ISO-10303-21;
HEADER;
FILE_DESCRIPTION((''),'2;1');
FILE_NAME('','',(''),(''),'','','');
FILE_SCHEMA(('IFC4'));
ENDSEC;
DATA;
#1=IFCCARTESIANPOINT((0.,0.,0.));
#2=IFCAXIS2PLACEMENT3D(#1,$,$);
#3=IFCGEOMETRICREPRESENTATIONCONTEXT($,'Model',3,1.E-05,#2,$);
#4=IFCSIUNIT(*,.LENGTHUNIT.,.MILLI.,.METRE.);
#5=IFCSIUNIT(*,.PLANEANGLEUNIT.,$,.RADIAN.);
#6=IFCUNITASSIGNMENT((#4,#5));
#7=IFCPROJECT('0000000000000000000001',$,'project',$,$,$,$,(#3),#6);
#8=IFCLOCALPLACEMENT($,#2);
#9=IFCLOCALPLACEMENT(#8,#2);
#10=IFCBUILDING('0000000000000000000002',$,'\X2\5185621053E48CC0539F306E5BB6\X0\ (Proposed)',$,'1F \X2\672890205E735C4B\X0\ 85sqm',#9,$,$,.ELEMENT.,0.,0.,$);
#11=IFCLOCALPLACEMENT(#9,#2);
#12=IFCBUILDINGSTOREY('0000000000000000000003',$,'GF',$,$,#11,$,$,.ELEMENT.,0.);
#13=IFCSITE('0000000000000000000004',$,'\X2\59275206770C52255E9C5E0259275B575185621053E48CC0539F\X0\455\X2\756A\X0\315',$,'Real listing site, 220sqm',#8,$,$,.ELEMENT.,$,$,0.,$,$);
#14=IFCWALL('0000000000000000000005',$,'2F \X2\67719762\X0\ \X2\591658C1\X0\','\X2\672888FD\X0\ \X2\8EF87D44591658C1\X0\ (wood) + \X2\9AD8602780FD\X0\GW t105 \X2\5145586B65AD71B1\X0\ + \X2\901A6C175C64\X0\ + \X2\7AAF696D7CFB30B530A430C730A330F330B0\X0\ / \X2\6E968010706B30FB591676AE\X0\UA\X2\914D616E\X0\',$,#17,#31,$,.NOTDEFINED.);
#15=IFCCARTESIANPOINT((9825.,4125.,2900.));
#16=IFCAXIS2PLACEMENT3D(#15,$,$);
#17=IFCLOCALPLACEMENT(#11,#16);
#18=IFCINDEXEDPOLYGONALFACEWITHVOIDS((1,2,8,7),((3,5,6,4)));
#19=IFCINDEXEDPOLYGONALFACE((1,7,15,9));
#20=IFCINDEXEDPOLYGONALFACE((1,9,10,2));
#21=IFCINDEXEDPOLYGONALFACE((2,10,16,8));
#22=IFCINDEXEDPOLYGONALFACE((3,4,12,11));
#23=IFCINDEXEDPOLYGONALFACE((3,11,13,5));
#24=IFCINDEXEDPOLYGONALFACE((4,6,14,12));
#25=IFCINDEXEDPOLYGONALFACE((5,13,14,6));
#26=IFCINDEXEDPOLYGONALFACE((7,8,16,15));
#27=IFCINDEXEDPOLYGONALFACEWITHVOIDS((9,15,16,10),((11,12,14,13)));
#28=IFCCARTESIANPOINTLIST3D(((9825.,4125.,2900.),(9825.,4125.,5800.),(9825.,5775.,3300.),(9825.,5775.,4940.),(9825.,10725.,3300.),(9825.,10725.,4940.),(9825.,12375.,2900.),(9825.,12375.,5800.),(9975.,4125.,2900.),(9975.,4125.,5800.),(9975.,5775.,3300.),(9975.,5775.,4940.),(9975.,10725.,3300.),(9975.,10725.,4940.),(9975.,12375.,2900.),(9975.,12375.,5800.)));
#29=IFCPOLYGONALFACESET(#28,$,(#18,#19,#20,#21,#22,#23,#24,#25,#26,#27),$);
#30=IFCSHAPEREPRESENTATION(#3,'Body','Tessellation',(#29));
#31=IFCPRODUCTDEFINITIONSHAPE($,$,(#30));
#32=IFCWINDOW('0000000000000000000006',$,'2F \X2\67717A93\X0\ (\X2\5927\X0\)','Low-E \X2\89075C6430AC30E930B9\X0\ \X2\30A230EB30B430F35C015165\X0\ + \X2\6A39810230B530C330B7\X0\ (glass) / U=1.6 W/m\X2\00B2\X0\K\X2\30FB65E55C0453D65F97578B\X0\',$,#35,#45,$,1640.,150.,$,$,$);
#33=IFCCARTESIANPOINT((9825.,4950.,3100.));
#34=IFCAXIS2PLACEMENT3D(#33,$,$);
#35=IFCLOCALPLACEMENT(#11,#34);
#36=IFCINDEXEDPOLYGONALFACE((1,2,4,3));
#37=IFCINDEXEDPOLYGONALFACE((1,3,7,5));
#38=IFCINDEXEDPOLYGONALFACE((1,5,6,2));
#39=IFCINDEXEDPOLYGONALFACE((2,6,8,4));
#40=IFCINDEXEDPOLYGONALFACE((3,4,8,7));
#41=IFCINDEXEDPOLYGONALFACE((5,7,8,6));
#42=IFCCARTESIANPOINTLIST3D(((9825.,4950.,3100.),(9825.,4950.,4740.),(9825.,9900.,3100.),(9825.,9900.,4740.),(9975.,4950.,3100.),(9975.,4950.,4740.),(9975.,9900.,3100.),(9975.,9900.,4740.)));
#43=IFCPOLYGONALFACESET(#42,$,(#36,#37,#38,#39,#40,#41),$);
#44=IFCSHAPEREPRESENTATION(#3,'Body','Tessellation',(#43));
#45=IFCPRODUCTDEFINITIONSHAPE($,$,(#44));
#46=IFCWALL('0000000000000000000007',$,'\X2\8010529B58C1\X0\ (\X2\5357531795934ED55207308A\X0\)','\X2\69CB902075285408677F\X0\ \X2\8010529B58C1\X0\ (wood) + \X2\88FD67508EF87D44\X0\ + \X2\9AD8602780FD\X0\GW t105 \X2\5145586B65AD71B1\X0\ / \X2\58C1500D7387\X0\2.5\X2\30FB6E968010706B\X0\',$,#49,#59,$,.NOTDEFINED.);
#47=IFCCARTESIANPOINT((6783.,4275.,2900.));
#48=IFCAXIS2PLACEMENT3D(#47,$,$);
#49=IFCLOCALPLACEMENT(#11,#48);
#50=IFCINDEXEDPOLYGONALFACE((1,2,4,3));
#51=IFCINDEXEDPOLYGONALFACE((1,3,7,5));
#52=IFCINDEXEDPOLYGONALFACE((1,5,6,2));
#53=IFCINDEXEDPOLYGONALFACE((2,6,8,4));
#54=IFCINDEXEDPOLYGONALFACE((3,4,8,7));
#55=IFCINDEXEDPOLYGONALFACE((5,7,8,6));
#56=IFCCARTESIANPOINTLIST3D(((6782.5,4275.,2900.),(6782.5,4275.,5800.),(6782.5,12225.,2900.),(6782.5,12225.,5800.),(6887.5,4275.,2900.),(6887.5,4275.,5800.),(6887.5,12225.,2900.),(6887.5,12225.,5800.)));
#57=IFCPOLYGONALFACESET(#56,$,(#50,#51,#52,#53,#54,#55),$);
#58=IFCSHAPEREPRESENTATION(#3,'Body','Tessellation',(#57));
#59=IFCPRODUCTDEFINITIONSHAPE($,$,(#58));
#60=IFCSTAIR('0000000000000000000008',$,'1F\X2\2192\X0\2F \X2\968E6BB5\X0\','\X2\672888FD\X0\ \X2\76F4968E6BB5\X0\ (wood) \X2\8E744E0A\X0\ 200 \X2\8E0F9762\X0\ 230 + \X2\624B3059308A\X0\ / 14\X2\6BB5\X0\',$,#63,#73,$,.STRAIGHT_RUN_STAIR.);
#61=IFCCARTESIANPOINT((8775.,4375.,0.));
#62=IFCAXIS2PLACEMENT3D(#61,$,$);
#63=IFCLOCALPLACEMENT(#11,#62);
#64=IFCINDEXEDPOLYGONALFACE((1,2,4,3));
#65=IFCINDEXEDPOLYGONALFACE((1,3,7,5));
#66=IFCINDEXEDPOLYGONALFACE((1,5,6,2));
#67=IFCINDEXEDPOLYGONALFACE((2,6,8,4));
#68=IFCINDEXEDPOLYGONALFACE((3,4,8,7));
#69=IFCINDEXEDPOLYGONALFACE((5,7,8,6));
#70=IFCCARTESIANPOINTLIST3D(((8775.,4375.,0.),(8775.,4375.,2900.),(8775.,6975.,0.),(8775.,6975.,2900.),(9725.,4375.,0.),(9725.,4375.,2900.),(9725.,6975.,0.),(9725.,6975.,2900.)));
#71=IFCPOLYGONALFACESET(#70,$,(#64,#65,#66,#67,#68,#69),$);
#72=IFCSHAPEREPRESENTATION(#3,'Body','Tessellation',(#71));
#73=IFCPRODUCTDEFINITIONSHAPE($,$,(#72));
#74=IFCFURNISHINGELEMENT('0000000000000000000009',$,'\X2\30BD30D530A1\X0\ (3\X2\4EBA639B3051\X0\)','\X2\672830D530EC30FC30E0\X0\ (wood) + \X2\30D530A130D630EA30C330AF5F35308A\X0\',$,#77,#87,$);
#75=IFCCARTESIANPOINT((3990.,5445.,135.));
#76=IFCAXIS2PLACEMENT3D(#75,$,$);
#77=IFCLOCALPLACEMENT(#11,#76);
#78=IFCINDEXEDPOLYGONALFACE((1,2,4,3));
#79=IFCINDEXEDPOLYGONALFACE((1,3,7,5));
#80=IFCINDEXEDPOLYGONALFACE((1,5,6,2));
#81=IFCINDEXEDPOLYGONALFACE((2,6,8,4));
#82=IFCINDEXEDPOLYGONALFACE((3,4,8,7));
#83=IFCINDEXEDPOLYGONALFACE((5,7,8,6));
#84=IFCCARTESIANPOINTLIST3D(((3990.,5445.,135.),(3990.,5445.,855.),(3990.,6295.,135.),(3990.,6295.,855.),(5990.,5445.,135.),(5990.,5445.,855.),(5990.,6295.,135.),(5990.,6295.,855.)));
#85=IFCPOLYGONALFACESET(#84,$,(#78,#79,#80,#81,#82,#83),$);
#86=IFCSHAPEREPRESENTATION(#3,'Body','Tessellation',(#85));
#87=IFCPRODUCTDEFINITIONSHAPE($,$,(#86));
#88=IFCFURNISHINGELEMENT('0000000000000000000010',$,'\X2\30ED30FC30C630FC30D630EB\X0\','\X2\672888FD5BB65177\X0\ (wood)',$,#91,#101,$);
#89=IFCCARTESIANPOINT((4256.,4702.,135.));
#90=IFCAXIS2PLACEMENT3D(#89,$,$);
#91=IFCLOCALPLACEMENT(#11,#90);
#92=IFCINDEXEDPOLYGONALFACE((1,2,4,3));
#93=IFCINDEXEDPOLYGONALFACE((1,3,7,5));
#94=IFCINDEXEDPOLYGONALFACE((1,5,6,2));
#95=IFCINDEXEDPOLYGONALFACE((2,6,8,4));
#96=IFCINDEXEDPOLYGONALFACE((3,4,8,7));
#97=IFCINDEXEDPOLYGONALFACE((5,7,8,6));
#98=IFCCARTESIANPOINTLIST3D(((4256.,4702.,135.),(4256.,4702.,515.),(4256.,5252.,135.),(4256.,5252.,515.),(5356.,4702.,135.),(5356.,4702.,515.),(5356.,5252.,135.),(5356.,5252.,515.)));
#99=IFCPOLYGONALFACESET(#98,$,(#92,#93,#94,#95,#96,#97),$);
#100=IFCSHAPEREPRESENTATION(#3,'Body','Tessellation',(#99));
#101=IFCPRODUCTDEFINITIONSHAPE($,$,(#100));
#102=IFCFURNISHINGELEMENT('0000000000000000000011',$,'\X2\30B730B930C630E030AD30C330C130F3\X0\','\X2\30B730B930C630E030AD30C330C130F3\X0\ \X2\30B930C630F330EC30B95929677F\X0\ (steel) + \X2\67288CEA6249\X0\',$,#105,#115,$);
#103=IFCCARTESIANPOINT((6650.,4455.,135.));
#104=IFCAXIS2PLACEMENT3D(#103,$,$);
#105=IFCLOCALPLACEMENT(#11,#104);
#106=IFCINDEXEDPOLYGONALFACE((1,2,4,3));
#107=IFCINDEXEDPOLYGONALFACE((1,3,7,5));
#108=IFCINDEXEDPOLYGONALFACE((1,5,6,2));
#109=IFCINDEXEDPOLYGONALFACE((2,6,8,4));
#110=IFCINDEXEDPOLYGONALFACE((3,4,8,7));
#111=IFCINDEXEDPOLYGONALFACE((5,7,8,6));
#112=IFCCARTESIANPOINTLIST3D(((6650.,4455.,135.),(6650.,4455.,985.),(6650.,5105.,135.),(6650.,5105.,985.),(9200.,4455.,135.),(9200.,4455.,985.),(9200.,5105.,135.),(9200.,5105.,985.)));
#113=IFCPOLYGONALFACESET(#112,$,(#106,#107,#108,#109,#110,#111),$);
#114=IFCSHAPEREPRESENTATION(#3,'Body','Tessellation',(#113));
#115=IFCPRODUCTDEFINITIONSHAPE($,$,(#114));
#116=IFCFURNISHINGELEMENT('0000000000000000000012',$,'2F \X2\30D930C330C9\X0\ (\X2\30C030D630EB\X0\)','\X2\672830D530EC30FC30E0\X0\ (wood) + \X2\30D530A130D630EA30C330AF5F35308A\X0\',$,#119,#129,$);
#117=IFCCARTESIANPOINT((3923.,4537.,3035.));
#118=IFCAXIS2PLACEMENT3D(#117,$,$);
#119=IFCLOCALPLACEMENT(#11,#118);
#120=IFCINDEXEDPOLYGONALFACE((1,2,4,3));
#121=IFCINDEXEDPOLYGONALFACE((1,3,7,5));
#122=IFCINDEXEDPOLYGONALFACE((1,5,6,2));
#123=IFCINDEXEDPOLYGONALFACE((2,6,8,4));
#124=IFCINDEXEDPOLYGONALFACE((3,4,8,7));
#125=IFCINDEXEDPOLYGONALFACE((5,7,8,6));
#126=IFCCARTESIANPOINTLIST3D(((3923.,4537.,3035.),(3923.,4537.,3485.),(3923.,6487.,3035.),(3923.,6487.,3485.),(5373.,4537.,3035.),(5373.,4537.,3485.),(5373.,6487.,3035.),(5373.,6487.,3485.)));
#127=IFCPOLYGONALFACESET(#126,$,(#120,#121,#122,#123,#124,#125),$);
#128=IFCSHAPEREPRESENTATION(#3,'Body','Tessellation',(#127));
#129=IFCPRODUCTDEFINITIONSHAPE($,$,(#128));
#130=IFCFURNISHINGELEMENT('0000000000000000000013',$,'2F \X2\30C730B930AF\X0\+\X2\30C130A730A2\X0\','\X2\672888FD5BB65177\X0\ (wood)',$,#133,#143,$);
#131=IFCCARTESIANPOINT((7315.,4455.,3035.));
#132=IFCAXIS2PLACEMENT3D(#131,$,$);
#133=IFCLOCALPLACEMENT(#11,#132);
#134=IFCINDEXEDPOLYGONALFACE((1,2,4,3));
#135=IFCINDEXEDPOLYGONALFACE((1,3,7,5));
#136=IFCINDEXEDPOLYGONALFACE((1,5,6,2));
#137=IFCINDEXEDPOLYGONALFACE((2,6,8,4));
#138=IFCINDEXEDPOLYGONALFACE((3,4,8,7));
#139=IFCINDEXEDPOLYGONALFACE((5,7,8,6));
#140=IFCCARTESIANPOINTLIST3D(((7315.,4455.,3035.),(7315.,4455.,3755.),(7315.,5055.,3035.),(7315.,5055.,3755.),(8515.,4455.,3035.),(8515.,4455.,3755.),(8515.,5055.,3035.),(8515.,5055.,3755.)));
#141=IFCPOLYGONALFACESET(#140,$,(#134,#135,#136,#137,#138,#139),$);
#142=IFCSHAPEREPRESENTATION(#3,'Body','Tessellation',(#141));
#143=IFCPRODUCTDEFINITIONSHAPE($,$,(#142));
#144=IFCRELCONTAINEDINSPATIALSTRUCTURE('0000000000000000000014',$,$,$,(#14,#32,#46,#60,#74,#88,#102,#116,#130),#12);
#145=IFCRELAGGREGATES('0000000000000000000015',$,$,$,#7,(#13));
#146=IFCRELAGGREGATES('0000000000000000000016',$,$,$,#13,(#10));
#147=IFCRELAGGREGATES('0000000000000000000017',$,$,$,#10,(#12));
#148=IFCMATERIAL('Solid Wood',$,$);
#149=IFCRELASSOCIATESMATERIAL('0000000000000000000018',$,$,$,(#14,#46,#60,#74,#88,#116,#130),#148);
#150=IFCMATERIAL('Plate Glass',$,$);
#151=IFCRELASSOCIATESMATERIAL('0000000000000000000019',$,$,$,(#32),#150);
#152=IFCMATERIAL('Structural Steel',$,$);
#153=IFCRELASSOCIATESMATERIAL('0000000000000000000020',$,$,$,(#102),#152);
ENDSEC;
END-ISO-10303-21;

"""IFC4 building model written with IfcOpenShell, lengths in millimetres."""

from ifc_helpers import new_model, si_unit, frame, frame_2d, origin, place, context, project, spatial, rectangle, extrude, material, element, fill, save


model = new_model("IFC4")

# Units and contexts
model_context = context("Model", 3, precision=1e-05, world=origin())
ifc_project = project(units=[si_unit("LENGTHUNIT", "METRE", prefix="MILLI"), si_unit("PLANEANGLEUNIT", "RADIAN")], contexts=[model_context])

# Site, building, storey
site_placement = place(None, origin())
site = spatial("IfcSite", under=ifc_project, at=site_placement, Name="大分県別府市大字内成古賀原455番315", ObjectType="Real listing site, 220sqm", CompositionType="ELEMENT", RefElevation=0.0)
building_placement = place(site_placement, origin())
building = spatial("IfcBuilding", under=site, at=building_placement, Name="内成古賀原の家 (Proposed)", ObjectType="1F 木造平屋 85sqm", CompositionType="ELEMENT", ElevationOfRefHeight=0.0, ElevationOfTerrain=0.0)
storey_placement = place(building_placement, origin())
storey = spatial("IfcBuildingStorey", under=building, at=storey_placement, Name="GF", CompositionType="ELEMENT", Elevation=0.0)

# Shared definitions
ifc_material_1 = material(Name="Solid Wood")
ifc_material_2 = material(Name="Plate Glass")

# Wall, opening, window
wall_1_placement = place(storey_placement, frame((9825.0, 4125.0, 2900.0)))
wall_1 = element("IfcWall", 1, at=wall_1_placement, inside=storey, material=ifc_material_1, Name="2F 東面 外壁", Description="木製 軸組外壁 (wood) + 高性能GW t105 充填断熱 + 通気層 + 窯業系サイディング / 準耐火・外皮UA配慮", PredefinedType="NOTDEFINED", context=model_context, shape_type="SweptSolid", body=[
    extrude(rectangle(XDim=150.0, YDim=8250.0, at=frame_2d((75.0, 4125.0))), frame((9825.0, 4125.0, 2900.0)), (0.0, 0.0, 1.0), 2900.0),
])
opening_1_placement = place(storey_placement, frame((9825.0, 4950.0, 3100.0)))
opening_1 = element("IfcOpeningElement", 2, at=opening_1_placement, cuts=wall_1, PredefinedType="NOTDEFINED", context=model_context, shape_type="SweptSolid", body=[
    extrude(rectangle(XDim=150.0, YDim=4950.0, at=frame_2d((75.0, 2475.0))), frame((9825.0, 4950.0, 3100.0)), (0.0, 0.0, 1.0), 1640.0),
])
window_1_placement = place(storey_placement, frame((9825.0, 4950.0, 3100.0)))
window_1 = element("IfcWindow", 3, at=window_1_placement, inside=storey, material=ifc_material_2, Name="2F 東窓 (大)", Description="Low-E 複層ガラス アルゴン封入 + 樹脂サッシ (glass) / U=1.6 W/m²K・日射取得型", OverallHeight=1640.0, OverallWidth=150.0, context=model_context, shape_type="SweptSolid", body=[
    extrude(rectangle(XDim=150.0, YDim=4950.0, at=frame_2d((75.0, 2475.0))), frame((9825.0, 4950.0, 3100.0)), (0.0, 0.0, 1.0), 1640.0),
])
fill(opening_1, window_1)

# Wall
wall_2_placement = place(storey_placement, frame((6783.0, 4275.0, 2900.0)))
element("IfcWall", 4, at=wall_2_placement, inside=storey, material=ifc_material_1, Name="耐力壁 (南北間仕切り)", Description="構造用合板 耐力壁 (wood) + 製材軸組 + 高性能GW t105 充填断熱 / 壁倍率2.5・準耐火", PredefinedType="NOTDEFINED", context=model_context, shape_type="SweptSolid", body=[
    extrude(rectangle(XDim=105.0, YDim=7950.0, at=frame_2d((52.0, 3975.0))), frame((6783.0, 4275.0, 2900.0)), (0.0, 0.0, 1.0), 2900.0),
])

# Stair
stair_placement = place(storey_placement, frame((8775.0, 4375.0, 0.0)))
element("IfcStair", 5, at=stair_placement, inside=storey, material=ifc_material_1, Name="1F→2F 階段", Description="木製 直階段 (wood) 蹴上 200 踏面 230 + 手すり / 14段", PredefinedType="STRAIGHT_RUN_STAIR", context=model_context, shape_type="SweptSolid", body=[
    extrude(rectangle(XDim=950.0, YDim=2600.0, at=frame_2d((475.0, 1300.0))), frame((8775.0, 4375.0, 0.0)), (0.0, 0.0, 1.0), 2900.0),
])

# Furnishing elements
furnishing_1_placement = place(storey_placement, frame((3990.0, 5445.0, 135.0)))
element("IfcFurnishingElement", 6, at=furnishing_1_placement, inside=storey, material=ifc_material_1, Name="ソファ (3人掛け)", Description="木フレーム (wood) + ファブリック張り", context=model_context, shape_type="SweptSolid", body=[
    extrude(rectangle(XDim=2000.0, YDim=850.0, at=frame_2d((1000.0, 425.0))), frame((3990.0, 5445.0, 135.0)), (0.0, 0.0, 1.0), 720.0),
])
furnishing_2_placement = place(storey_placement, frame((4256.0, 4702.0, 135.0)))
element("IfcFurnishingElement", 7, at=furnishing_2_placement, inside=storey, material=ifc_material_1, Name="ローテーブル", Description="木製家具 (wood)", context=model_context, shape_type="SweptSolid", body=[
    extrude(rectangle(XDim=1100.0, YDim=550.0, at=frame_2d((550.0, 275.0))), frame((4256.0, 4702.0, 135.0)), (0.0, 0.0, 1.0), 380.0),
])
ifc_material_3 = material(Name="Structural Steel")
furnishing_3_placement = place(storey_placement, frame((6650.0, 4455.0, 135.0)))
element("IfcFurnishingElement", 8, at=furnishing_3_placement, inside=storey, material=ifc_material_3, Name="システムキッチン", Description="システムキッチン ステンレス天板 (steel) + 木質扉", context=model_context, shape_type="SweptSolid", body=[
    extrude(rectangle(XDim=2550.0, YDim=650.0, at=frame_2d((1275.0, 325.0))), frame((6650.0, 4455.0, 135.0)), (0.0, 0.0, 1.0), 850.0),
])
furnishing_4_placement = place(storey_placement, frame((3923.0, 4537.0, 3035.0)))
element("IfcFurnishingElement", 9, at=furnishing_4_placement, inside=storey, material=ifc_material_1, Name="2F ベッド (ダブル)", Description="木フレーム (wood) + ファブリック張り", context=model_context, shape_type="SweptSolid", body=[
    extrude(rectangle(XDim=1450.0, YDim=1950.0, at=frame_2d((725.0, 975.0))), frame((3923.0, 4537.0, 3035.0)), (0.0, 0.0, 1.0), 450.0),
])
furnishing_5_placement = place(storey_placement, frame((7315.0, 4455.0, 3035.0)))
element("IfcFurnishingElement", 10, at=furnishing_5_placement, inside=storey, material=ifc_material_1, Name="2F デスク+チェア", Description="木製家具 (wood)", context=model_context, shape_type="SweptSolid", body=[
    extrude(rectangle(XDim=1200.0, YDim=600.0, at=frame_2d((600.0, 300.0))), frame((7315.0, 4455.0, 3035.0)), (0.0, 0.0, 1.0), 720.0),
])

save(model, "model.ifc")
